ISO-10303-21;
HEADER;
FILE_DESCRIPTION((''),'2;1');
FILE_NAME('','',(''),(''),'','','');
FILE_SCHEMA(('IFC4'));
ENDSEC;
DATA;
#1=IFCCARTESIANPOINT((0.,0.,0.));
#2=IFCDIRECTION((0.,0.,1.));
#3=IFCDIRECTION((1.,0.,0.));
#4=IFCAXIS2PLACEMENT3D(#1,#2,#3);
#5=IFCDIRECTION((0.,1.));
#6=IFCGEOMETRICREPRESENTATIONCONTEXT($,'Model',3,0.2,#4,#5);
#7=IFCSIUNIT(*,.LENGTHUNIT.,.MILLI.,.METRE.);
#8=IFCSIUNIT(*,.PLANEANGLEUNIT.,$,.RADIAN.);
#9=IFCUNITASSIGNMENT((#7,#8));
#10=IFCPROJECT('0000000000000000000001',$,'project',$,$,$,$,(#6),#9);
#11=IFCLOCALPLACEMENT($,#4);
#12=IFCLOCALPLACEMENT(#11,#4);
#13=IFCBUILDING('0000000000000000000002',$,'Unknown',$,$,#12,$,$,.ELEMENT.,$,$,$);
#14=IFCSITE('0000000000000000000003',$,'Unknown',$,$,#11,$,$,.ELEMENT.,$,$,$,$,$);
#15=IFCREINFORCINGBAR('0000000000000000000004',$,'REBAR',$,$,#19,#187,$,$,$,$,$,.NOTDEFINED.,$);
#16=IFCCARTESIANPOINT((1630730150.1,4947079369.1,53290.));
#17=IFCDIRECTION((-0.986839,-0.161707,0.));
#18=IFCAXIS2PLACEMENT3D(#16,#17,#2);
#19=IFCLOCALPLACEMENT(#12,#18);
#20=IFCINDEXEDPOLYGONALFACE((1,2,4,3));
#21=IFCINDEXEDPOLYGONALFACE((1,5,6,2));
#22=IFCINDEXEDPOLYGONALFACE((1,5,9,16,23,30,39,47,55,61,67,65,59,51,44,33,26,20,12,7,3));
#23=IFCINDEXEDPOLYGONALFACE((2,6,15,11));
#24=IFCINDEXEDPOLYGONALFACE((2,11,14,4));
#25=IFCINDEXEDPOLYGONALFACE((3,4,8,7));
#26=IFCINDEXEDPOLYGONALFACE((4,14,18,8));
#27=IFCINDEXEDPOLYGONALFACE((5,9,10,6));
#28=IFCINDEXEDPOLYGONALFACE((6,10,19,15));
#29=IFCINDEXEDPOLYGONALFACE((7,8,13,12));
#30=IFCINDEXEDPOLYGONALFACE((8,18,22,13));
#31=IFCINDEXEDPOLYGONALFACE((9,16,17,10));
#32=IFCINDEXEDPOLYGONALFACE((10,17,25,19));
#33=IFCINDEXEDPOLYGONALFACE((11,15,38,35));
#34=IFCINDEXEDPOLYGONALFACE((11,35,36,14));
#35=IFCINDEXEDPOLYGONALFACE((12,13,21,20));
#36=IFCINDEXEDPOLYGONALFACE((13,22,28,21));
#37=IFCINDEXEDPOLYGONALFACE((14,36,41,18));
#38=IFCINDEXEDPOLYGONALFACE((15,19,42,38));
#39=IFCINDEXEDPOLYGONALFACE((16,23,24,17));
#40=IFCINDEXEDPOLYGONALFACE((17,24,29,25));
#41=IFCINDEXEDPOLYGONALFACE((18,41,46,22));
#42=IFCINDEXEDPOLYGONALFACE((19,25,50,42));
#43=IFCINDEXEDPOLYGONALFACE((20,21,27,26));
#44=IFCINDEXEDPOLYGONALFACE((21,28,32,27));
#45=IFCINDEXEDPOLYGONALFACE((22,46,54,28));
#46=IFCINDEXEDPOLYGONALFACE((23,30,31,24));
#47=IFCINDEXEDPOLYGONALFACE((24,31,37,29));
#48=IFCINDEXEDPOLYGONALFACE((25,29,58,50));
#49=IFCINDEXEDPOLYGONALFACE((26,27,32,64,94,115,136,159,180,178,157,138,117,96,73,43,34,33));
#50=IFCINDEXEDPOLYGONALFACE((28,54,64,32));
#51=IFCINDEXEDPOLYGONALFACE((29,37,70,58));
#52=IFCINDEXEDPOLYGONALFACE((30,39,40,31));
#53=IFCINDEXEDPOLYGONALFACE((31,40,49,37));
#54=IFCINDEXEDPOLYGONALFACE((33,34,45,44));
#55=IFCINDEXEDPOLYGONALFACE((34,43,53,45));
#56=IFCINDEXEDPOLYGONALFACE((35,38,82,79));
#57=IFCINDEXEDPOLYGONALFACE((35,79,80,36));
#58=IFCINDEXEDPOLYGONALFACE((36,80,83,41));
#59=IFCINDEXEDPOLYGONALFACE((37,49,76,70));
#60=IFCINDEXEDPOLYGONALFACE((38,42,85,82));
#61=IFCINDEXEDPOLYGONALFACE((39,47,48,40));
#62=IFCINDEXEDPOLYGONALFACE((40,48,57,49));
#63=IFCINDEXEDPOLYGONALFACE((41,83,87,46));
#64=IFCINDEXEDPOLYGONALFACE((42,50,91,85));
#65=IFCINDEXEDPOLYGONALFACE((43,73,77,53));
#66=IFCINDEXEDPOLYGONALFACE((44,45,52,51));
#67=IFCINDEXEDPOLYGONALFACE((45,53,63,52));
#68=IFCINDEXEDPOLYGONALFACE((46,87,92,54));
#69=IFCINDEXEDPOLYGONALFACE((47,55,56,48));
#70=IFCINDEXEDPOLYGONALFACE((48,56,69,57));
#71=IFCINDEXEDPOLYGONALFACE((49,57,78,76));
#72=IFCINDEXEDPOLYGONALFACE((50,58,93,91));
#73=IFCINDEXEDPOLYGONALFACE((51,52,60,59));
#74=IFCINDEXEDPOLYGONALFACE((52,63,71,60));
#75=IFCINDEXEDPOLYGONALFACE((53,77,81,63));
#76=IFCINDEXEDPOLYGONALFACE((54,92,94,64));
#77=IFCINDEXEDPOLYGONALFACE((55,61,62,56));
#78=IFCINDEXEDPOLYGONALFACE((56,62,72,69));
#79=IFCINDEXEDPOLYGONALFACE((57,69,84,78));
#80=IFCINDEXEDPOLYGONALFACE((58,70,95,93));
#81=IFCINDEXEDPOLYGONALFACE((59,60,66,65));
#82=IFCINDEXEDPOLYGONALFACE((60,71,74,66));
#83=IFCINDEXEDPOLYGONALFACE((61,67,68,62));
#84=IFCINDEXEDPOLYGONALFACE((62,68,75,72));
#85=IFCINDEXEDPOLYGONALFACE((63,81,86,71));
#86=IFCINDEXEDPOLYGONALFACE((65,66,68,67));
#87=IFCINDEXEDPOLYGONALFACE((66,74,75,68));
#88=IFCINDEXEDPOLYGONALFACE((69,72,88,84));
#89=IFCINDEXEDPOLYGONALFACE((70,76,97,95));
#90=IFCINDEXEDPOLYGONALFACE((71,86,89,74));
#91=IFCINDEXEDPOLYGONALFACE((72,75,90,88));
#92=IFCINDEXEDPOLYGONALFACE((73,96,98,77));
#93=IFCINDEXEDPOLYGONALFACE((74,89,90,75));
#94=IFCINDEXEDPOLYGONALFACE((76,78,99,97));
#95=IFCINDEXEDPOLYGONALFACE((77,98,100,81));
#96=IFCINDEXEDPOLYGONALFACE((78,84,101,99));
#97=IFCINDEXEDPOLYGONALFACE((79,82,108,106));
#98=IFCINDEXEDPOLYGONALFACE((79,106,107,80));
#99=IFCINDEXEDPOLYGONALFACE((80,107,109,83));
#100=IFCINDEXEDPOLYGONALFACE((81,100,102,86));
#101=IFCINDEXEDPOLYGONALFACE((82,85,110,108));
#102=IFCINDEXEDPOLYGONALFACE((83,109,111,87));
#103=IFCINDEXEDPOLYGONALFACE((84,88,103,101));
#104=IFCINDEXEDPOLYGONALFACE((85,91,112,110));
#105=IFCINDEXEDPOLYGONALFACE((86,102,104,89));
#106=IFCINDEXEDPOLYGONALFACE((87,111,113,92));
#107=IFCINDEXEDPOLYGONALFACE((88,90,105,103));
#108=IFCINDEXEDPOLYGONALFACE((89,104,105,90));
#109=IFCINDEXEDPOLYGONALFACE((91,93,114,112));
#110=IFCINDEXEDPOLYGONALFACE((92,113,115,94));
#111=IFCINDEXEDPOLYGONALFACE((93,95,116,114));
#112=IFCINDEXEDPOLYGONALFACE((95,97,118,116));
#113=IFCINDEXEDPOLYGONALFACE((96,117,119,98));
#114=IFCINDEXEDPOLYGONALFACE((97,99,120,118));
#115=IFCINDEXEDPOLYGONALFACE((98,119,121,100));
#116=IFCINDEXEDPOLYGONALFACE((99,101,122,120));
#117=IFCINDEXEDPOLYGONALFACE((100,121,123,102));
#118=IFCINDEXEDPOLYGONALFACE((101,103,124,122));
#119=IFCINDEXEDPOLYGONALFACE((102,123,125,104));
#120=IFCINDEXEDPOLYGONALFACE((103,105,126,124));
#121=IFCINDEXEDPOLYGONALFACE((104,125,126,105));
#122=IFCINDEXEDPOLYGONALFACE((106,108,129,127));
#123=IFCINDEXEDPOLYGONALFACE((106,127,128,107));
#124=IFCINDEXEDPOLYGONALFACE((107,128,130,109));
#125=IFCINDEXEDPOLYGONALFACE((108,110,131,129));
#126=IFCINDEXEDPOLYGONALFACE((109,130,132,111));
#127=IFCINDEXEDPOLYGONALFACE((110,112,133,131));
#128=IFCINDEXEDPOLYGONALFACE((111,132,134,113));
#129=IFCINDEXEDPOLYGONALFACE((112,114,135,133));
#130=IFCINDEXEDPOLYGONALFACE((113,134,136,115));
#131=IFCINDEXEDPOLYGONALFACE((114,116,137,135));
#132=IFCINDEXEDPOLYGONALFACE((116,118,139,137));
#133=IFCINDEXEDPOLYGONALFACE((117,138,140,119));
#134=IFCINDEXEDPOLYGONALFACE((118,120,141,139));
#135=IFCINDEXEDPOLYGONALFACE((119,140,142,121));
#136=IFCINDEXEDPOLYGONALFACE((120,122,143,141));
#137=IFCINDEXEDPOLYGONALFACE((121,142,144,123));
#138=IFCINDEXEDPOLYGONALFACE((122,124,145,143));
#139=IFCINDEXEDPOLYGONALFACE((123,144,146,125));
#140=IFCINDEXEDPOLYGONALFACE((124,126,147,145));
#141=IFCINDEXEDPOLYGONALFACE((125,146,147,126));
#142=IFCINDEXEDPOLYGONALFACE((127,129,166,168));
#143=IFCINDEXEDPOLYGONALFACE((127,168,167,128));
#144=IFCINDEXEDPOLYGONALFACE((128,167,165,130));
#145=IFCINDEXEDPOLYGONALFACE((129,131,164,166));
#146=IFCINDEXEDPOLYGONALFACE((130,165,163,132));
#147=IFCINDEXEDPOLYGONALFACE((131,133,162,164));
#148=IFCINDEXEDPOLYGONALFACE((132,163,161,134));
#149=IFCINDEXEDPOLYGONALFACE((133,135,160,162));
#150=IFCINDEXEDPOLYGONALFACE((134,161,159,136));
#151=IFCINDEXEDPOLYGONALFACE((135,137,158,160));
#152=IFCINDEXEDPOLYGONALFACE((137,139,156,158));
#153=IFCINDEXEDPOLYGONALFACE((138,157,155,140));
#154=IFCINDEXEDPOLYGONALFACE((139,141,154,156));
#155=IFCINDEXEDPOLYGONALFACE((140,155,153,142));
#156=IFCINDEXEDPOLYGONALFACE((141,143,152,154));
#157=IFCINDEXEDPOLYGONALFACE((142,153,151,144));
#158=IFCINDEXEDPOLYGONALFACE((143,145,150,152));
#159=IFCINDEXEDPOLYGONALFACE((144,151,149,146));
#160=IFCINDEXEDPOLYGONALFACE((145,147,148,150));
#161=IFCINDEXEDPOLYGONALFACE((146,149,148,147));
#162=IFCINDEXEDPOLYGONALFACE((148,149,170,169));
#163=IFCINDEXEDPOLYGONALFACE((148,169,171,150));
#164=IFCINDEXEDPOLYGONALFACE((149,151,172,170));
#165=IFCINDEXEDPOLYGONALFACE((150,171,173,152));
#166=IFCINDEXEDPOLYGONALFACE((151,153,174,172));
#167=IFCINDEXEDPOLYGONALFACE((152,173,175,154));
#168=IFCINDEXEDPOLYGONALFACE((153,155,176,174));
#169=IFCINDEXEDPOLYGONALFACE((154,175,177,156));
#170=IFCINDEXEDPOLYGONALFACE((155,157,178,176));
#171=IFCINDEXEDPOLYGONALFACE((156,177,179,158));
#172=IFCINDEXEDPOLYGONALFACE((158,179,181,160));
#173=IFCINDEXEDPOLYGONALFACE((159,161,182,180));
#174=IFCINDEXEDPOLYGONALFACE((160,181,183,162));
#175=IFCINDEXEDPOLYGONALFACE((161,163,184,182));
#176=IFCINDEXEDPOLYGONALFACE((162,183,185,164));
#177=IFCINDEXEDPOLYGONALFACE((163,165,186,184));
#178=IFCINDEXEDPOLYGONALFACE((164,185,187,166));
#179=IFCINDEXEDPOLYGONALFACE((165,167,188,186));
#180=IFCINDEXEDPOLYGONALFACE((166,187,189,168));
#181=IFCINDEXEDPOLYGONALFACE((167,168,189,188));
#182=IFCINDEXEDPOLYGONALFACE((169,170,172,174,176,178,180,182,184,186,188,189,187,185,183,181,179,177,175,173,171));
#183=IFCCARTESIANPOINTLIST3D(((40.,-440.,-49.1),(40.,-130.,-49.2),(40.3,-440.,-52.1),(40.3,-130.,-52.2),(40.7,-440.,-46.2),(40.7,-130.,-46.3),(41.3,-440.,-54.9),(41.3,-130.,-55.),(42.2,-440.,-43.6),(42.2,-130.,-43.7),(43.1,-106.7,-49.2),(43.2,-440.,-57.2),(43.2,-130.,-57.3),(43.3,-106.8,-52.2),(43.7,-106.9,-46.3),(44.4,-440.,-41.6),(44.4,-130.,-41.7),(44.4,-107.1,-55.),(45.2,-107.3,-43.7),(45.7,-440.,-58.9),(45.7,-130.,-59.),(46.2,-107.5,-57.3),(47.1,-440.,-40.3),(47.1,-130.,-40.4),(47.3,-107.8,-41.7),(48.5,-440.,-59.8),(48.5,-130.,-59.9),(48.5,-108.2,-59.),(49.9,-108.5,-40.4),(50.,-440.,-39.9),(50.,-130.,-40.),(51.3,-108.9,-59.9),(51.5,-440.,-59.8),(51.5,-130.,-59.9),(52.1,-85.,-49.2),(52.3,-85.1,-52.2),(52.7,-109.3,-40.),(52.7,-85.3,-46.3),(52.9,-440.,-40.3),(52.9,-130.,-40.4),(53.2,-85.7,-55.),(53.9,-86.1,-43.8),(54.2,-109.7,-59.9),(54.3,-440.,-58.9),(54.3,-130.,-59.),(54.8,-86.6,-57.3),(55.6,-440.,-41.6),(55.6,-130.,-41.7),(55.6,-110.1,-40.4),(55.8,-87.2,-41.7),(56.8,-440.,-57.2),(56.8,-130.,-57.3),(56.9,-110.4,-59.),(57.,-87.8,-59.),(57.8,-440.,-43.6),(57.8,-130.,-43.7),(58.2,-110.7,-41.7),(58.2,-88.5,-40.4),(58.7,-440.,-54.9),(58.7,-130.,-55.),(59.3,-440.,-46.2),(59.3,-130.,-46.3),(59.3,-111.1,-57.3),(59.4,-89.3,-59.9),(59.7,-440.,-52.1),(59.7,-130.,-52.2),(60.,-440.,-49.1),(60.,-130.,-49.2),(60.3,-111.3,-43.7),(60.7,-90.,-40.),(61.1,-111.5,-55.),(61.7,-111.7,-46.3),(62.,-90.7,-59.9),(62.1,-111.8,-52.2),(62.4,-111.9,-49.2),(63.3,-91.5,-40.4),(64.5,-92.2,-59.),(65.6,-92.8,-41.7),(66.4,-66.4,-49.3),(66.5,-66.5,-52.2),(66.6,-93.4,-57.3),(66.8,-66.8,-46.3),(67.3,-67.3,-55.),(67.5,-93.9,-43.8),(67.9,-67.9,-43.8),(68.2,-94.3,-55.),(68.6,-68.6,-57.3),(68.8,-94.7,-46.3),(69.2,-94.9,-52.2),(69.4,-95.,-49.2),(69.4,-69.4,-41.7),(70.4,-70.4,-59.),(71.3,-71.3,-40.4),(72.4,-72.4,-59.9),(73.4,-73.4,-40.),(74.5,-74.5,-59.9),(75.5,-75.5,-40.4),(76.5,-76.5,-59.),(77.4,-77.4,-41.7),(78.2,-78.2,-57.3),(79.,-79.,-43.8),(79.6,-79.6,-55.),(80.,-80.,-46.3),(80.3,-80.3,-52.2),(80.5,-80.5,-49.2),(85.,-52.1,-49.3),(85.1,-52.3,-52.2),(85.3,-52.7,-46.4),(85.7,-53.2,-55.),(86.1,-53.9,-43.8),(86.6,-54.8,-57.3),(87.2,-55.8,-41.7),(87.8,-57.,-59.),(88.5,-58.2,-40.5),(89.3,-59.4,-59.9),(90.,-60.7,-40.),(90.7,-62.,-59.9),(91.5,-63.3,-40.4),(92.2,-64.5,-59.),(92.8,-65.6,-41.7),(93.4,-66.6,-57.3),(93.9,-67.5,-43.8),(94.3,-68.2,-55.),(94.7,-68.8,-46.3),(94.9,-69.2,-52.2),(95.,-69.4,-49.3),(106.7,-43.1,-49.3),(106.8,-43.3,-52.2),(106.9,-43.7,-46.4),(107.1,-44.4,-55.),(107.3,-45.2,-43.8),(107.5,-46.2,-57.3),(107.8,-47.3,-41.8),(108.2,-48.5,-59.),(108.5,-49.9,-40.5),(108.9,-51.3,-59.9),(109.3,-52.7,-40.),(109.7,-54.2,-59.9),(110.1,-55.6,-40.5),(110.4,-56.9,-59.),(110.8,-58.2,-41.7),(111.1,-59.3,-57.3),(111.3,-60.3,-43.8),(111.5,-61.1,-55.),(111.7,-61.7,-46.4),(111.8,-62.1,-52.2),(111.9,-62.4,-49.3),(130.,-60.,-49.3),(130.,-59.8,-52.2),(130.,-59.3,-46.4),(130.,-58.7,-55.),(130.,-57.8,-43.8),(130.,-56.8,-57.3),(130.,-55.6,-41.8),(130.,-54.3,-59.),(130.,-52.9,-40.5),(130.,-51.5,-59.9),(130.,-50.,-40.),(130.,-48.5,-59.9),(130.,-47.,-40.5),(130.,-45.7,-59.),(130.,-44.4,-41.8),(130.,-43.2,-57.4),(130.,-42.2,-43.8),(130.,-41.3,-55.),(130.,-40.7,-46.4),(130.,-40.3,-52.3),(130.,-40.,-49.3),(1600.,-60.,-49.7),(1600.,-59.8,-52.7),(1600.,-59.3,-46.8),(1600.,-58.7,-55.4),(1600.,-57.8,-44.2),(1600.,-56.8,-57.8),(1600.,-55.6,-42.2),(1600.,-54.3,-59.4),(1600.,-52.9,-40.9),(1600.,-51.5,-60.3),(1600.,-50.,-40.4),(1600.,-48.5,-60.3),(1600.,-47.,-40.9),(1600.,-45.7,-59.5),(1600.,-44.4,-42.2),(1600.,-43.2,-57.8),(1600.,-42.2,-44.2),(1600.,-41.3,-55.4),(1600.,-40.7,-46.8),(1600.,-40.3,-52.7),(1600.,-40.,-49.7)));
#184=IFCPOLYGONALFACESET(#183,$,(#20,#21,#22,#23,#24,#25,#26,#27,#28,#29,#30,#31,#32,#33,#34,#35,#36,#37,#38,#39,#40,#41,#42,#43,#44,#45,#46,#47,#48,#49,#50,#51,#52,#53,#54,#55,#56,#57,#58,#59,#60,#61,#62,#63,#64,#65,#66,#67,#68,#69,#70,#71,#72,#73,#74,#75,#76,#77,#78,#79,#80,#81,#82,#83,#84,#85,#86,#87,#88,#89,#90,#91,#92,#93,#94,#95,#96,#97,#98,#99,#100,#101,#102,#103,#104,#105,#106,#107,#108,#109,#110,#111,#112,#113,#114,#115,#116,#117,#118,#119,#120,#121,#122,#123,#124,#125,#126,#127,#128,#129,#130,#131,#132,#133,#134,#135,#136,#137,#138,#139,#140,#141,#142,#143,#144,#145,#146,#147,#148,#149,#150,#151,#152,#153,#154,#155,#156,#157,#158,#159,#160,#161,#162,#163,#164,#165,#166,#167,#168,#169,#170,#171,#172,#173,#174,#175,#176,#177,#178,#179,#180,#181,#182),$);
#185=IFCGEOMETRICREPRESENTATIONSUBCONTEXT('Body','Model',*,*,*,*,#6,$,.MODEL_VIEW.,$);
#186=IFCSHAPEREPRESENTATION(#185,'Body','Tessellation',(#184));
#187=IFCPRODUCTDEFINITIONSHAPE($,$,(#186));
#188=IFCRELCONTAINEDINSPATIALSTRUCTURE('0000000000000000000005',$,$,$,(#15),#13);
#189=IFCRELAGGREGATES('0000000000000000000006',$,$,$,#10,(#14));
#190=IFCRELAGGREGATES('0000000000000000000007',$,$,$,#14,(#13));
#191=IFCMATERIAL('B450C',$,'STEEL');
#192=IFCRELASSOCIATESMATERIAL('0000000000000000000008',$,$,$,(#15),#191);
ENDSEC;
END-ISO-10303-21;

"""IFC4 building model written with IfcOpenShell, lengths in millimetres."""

from ifc_helpers import new_model, entity, si_unit, direction, frame, origin_with_axes, place, context, subcontext, project, spatial, material, element, save


model = new_model("IFC4")

# Units and contexts
model_context = context("Model", 3, precision=0.2, world=origin_with_axes(), true_north=direction((0.0, 1.0)))
body_context = subcontext(model_context, "Body", "Model", "MODEL_VIEW")
ifc_project = project(units=[si_unit("LENGTHUNIT", "METRE", prefix="MILLI"), si_unit("PLANEANGLEUNIT", "RADIAN")], contexts=[model_context])

# Site, building
site_placement = place(None, origin_with_axes())
site = spatial("IfcSite", under=ifc_project, at=site_placement, Name="Unknown", CompositionType="ELEMENT")
building_placement = place(site_placement, origin_with_axes())
building = spatial("IfcBuilding", under=site, at=building_placement, Name="Unknown", CompositionType="ELEMENT")

# Reinforcing bar
ifc_material = material(Name="B450C", Category="STEEL")
reinforcing_bar_1_placement = place(building_placement, frame((1630730150.1, 4947079369.1, 53290.0), z_axis=(-0.986839, -0.161707, 0.0), x_axis=(0.0, 0.0, 1.0)))
element("IfcReinforcingBar", 1, at=reinforcing_bar_1_placement, inside=building, material=ifc_material, Name="REBAR", PredefinedType="NOTDEFINED", context=body_context, shape_type="AdvancedSweptSolid", body=[
    entity("IfcSweptDiskSolid", entity("IfcIndexedPolyCurve", entity("IfcCartesianPointList3D", [[50.0, -440.0, -49.9], [50.0, -130.0, -50.0], [73.4, -73.4, -50.0], [130.0, -50.0, -50.0], [1600.0, -50.0, -50.4]]), [entity("IfcLineIndex", [1, 2]), entity("IfcArcIndex", [2, 3, 4]), entity("IfcLineIndex", [4, 5])]), 10.0),
])

save(model, "model.ifc")
